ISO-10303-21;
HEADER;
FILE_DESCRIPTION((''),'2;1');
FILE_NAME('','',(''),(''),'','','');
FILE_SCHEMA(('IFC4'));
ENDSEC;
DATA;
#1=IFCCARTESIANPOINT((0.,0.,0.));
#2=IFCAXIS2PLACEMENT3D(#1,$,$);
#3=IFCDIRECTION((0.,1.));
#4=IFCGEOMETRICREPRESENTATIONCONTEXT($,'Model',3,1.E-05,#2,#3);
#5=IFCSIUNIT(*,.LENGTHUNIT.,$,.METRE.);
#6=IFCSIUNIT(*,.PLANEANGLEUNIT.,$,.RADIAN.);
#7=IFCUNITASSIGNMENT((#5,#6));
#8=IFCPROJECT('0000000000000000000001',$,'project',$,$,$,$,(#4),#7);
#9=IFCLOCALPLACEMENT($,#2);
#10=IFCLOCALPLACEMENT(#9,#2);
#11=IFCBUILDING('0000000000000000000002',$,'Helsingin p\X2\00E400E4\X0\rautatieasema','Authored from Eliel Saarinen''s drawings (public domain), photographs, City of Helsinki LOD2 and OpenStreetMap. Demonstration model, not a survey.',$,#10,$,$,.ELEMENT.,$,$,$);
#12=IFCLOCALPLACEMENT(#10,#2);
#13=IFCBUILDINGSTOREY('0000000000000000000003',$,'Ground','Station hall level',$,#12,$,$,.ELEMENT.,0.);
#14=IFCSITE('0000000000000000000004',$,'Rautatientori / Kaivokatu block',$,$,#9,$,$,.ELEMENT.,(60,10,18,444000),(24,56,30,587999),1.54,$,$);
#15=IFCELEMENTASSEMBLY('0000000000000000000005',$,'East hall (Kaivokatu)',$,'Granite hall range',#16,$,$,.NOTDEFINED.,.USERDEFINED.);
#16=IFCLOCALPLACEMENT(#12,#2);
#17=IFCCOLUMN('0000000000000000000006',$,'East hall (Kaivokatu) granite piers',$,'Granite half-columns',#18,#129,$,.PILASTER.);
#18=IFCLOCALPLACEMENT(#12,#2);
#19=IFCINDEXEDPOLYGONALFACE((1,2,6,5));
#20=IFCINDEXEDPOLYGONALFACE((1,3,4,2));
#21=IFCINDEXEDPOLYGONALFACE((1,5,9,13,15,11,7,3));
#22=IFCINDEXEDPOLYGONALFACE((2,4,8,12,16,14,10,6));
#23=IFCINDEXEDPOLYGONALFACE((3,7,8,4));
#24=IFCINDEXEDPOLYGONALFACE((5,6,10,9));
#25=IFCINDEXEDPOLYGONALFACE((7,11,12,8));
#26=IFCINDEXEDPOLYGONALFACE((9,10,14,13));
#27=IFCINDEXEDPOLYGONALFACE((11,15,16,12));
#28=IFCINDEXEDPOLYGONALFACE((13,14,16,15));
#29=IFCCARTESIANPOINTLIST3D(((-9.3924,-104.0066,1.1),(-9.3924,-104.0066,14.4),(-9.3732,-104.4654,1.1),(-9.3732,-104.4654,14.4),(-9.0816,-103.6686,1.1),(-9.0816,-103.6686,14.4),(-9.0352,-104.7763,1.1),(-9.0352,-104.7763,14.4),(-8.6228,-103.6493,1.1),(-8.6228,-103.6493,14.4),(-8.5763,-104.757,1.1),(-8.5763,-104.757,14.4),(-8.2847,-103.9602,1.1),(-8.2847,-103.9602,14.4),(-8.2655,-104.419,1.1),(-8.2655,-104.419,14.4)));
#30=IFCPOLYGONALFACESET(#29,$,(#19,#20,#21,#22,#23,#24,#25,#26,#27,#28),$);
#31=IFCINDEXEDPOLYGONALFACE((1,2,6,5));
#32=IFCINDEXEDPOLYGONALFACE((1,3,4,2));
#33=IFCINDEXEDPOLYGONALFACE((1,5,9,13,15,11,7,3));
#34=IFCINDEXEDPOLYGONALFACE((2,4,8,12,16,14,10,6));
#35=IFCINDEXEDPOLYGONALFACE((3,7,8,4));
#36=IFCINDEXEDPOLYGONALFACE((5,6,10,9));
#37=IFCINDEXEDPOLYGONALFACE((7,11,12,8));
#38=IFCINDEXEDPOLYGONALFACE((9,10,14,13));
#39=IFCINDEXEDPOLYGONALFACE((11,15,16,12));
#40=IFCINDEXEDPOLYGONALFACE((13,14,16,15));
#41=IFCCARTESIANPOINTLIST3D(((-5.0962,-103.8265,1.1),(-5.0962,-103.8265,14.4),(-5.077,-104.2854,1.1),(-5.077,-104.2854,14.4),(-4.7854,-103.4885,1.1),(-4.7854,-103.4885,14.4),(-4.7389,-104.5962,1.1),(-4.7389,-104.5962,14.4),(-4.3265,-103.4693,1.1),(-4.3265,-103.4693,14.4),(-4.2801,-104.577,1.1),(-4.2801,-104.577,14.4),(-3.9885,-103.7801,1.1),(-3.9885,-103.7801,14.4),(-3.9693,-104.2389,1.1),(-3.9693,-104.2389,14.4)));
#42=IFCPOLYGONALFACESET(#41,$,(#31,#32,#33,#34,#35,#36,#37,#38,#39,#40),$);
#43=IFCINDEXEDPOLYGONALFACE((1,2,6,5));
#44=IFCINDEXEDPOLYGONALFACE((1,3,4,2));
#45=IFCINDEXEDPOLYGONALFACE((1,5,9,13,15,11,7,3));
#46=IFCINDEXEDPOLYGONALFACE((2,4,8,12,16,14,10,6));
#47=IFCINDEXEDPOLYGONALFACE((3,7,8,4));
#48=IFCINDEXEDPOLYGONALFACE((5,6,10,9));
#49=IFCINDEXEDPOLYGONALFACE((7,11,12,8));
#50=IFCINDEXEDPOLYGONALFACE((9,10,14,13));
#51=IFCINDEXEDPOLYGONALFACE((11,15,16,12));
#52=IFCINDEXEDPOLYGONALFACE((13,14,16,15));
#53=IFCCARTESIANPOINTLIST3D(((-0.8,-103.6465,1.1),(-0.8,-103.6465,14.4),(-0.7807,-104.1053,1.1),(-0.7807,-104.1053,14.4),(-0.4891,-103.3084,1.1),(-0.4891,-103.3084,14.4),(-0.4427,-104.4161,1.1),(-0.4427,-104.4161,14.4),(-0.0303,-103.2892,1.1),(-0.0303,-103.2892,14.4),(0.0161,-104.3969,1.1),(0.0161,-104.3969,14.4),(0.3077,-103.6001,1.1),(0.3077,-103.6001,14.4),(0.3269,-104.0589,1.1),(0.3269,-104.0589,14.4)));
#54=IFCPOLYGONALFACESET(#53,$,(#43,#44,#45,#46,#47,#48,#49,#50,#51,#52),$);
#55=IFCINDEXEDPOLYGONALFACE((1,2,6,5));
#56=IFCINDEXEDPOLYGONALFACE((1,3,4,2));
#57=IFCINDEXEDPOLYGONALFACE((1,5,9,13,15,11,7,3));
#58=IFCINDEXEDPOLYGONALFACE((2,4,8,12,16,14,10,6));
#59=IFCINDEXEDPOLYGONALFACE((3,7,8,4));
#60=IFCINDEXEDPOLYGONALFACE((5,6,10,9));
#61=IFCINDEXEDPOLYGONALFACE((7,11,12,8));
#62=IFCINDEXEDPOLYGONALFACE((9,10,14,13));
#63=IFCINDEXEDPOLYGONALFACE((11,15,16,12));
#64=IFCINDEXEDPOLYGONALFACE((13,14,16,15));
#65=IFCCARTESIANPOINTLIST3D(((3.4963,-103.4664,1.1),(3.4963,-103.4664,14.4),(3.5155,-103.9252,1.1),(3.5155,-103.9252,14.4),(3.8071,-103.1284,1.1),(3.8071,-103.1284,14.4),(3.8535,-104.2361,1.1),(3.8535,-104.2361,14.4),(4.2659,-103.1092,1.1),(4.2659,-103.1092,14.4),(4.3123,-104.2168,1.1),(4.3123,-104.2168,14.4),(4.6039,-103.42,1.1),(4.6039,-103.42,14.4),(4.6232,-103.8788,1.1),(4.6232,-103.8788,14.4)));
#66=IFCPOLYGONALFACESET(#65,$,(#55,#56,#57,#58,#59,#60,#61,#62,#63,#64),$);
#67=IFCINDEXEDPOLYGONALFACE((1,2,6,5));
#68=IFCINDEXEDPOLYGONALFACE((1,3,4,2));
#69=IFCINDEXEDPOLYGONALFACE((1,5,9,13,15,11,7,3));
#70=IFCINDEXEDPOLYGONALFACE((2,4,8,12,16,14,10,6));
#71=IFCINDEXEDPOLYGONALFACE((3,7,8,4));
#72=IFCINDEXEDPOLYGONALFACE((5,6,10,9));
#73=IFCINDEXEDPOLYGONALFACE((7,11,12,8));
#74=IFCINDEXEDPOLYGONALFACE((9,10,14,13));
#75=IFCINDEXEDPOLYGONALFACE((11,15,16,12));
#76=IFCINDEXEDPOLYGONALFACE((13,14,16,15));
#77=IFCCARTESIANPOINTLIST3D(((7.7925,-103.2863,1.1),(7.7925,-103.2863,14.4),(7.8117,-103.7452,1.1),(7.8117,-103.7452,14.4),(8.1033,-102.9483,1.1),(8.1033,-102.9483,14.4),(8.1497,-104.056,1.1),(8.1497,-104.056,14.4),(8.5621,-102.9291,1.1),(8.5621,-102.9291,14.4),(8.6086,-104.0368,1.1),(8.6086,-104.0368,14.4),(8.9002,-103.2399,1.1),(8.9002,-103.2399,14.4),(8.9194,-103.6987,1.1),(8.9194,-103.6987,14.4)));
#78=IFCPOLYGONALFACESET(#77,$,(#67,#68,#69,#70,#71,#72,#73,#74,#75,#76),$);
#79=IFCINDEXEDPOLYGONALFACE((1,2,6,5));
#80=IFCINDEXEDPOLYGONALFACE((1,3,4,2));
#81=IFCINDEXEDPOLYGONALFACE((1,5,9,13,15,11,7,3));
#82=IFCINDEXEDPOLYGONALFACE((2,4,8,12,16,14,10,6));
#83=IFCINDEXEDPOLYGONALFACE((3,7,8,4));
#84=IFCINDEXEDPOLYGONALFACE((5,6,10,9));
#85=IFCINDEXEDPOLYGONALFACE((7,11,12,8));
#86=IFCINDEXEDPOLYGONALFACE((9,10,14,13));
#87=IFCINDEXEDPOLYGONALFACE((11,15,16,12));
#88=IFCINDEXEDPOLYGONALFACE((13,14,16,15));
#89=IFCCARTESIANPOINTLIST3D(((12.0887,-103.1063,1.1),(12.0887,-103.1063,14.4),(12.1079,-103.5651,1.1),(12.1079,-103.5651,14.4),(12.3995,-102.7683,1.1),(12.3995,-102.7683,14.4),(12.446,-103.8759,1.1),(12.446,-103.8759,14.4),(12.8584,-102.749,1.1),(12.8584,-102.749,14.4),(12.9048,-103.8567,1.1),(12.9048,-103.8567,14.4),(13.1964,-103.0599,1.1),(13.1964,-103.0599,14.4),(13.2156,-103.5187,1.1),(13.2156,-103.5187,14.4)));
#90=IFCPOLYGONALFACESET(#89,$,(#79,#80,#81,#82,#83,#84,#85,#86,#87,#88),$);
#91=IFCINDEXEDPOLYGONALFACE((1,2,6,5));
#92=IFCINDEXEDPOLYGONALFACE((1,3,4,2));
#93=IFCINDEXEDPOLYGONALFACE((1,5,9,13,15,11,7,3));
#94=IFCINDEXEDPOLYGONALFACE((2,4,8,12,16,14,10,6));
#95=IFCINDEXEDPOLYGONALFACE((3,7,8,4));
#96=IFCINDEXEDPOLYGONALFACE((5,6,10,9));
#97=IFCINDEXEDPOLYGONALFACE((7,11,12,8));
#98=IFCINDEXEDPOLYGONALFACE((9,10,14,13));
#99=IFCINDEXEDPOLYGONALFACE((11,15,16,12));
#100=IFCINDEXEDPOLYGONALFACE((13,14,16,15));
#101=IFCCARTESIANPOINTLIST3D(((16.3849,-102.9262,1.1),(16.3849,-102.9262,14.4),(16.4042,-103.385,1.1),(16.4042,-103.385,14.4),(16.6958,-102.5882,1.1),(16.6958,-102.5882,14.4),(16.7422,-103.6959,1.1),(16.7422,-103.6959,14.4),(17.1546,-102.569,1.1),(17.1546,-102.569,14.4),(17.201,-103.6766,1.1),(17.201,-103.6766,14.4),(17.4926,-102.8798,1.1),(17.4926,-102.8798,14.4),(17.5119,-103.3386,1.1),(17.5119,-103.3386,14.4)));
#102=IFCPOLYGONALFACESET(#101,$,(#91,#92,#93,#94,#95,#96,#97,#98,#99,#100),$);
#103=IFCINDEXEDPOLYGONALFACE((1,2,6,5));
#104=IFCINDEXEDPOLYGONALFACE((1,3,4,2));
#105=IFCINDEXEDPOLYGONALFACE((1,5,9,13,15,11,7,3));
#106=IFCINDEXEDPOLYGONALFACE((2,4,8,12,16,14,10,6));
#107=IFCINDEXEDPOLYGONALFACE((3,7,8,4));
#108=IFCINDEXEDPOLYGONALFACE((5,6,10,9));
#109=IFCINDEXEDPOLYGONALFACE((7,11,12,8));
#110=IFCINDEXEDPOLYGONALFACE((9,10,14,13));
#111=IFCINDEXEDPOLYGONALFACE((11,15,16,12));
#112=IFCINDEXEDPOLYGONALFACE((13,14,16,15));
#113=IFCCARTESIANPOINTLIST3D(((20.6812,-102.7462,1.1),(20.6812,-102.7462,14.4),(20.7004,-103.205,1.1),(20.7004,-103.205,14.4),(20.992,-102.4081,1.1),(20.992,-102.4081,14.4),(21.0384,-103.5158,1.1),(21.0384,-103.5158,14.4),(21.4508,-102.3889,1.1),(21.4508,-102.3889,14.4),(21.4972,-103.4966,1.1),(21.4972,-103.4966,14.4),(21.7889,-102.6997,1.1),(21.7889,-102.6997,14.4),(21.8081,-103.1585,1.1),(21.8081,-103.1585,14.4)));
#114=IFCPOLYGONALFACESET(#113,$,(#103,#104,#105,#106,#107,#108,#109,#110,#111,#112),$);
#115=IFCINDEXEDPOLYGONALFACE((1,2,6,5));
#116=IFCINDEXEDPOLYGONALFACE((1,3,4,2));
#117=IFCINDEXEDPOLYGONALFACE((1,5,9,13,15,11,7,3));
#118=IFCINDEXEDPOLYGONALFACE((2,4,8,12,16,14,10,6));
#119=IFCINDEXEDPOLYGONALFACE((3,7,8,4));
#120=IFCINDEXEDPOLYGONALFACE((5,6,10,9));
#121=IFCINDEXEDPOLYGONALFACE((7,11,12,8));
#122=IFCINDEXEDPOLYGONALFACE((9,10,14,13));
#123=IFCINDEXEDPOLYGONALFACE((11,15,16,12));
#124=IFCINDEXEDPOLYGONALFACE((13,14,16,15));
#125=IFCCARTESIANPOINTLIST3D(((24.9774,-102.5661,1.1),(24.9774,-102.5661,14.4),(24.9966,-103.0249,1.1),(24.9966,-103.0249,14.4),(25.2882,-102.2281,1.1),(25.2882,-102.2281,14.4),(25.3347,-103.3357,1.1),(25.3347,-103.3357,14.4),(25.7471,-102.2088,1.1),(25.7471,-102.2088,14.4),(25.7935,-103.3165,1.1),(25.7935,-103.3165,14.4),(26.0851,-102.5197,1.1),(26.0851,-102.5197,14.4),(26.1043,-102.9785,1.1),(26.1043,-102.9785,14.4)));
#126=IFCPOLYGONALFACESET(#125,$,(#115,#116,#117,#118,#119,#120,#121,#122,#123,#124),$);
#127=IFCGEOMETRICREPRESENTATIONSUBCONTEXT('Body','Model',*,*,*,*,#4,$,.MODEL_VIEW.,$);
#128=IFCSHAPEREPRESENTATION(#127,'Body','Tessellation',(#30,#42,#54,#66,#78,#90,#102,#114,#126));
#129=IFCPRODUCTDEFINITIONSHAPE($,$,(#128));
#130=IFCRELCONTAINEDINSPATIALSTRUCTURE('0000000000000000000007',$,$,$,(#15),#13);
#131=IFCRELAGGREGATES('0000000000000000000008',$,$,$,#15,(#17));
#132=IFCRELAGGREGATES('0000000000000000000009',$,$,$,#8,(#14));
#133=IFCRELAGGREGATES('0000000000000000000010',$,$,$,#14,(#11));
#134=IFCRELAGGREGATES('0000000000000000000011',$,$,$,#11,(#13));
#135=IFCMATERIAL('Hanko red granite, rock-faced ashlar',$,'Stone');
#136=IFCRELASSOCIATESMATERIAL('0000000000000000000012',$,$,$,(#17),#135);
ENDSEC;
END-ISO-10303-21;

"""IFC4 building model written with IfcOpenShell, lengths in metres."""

from ifc_helpers import new_model, si_unit, direction, frame, origin, place, context, subcontext, project, spatial, polyline, outline, extrude, material, element, aggregate, save


model = new_model("IFC4")

# Units and contexts
model_context = context("Model", 3, precision=1e-05, world=origin(), true_north=direction((0.0, 1.0)))
body_context = subcontext(model_context, "Body", "Model", "MODEL_VIEW")
ifc_project = project(units=[si_unit("LENGTHUNIT", "METRE"), si_unit("PLANEANGLEUNIT", "RADIAN")], contexts=[model_context])

# Site, building, storey
site_placement = place(None, origin())
site = spatial("IfcSite", under=ifc_project, at=site_placement, Name="Rautatientori / Kaivokatu block", CompositionType="ELEMENT", RefLatitude=(60, 10, 18, 444000), RefLongitude=(24, 56, 30, 587999), RefElevation=1.54)
building_placement = place(site_placement, origin())
building = spatial("IfcBuilding", under=site, at=building_placement, Name="Helsingin päärautatieasema", Description="Authored from Eliel Saarinen's drawings (public domain), photographs, City of Helsinki LOD2 and OpenStreetMap. Demonstration model, not a survey.", CompositionType="ELEMENT")
storey_placement = place(building_placement, origin())
storey = spatial("IfcBuildingStorey", under=building, at=storey_placement, Name="Ground", Description="Station hall level", CompositionType="ELEMENT", Elevation=0.0)

# Element assembly, column
ifc_material_1 = material(Name="Hanko red granite, rock-faced ashlar", Category="Stone")
assembly_1_placement = place(building_placement, origin())
assembly_1 = element("IfcElementAssembly", 1, at=assembly_1_placement, inside=storey, Name="East hall (Kaivokatu)", ObjectType="Granite hall range", AssemblyPlace="NOTDEFINED", PredefinedType="USERDEFINED")
column_1_placement = place(building_placement, origin())
column_1 = element("IfcColumn", 2, at=column_1_placement, material=ifc_material_1, Name="East hall (Kaivokatu) granite piers", ObjectType="Granite half-columns", PredefinedType="PILASTER", context=body_context, shape_type="SweptSolid", body=[
    extrude(outline(polyline([(-8.2847, -103.9602), (-8.6228, -103.6493), (-9.0816, -103.6686), (-9.3924, -104.0066), (-9.3732, -104.4654), (-9.0352, -104.7763), (-8.5763, -104.757), (-8.2655, -104.419), (-8.2847, -103.9602)])), frame((0.0, 0.0, 1.1)), (0.0, 0.0, 1.0), 13.3),
    extrude(outline(polyline([(-3.9885, -103.7801), (-4.3265, -103.4693), (-4.7854, -103.4885), (-5.0962, -103.8265), (-5.077, -104.2854), (-4.7389, -104.5962), (-4.2801, -104.577), (-3.9693, -104.2389), (-3.9885, -103.7801)])), frame((0.0, 0.0, 1.1)), (0.0, 0.0, 1.0), 13.3),
    extrude(outline(polyline([(0.3077, -103.6001), (-0.0303, -103.2892), (-0.4891, -103.3084), (-0.8, -103.6465), (-0.7807, -104.1053), (-0.4427, -104.4161), (0.0161, -104.3969), (0.3269, -104.0589), (0.3077, -103.6001)])), frame((0.0, 0.0, 1.1)), (0.0, 0.0, 1.0), 13.3),
    extrude(outline(polyline([(4.6039, -103.42), (4.2659, -103.1092), (3.8071, -103.1284), (3.4963, -103.4664), (3.5155, -103.9252), (3.8535, -104.2361), (4.3123, -104.2168), (4.6232, -103.8788), (4.6039, -103.42)])), frame((0.0, 0.0, 1.1)), (0.0, 0.0, 1.0), 13.3),
    extrude(outline(polyline([(8.9002, -103.2399), (8.5621, -102.9291), (8.1033, -102.9483), (7.7925, -103.2863), (7.8117, -103.7452), (8.1497, -104.056), (8.6086, -104.0368), (8.9194, -103.6987), (8.9002, -103.2399)])), frame((0.0, 0.0, 1.1)), (0.0, 0.0, 1.0), 13.3),
    extrude(outline(polyline([(13.1964, -103.0599), (12.8584, -102.749), (12.3995, -102.7683), (12.0887, -103.1063), (12.1079, -103.5651), (12.446, -103.8759), (12.9048, -103.8567), (13.2156, -103.5187), (13.1964, -103.0599)])), frame((0.0, 0.0, 1.1)), (0.0, 0.0, 1.0), 13.3),
    extrude(outline(polyline([(17.4926, -102.8798), (17.1546, -102.569), (16.6958, -102.5882), (16.3849, -102.9262), (16.4042, -103.385), (16.7422, -103.6959), (17.201, -103.6766), (17.5119, -103.3386), (17.4926, -102.8798)])), frame((0.0, 0.0, 1.1)), (0.0, 0.0, 1.0), 13.3),
    extrude(outline(polyline([(21.7889, -102.6997), (21.4508, -102.3889), (20.992, -102.4081), (20.6812, -102.7462), (20.7004, -103.205), (21.0384, -103.5158), (21.4972, -103.4966), (21.8081, -103.1585), (21.7889, -102.6997)])), frame((0.0, 0.0, 1.1)), (0.0, 0.0, 1.0), 13.3),
    extrude(outline(polyline([(26.0851, -102.5197), (25.7471, -102.2088), (25.2882, -102.2281), (24.9774, -102.5661), (24.9966, -103.0249), (25.3347, -103.3357), (25.7935, -103.3165), (26.1043, -102.9785), (26.0851, -102.5197)])), frame((0.0, 0.0, 1.1)), (0.0, 0.0, 1.0), 13.3),
])

aggregate(assembly_1, [column_1])

save(model, "model.ifc")
